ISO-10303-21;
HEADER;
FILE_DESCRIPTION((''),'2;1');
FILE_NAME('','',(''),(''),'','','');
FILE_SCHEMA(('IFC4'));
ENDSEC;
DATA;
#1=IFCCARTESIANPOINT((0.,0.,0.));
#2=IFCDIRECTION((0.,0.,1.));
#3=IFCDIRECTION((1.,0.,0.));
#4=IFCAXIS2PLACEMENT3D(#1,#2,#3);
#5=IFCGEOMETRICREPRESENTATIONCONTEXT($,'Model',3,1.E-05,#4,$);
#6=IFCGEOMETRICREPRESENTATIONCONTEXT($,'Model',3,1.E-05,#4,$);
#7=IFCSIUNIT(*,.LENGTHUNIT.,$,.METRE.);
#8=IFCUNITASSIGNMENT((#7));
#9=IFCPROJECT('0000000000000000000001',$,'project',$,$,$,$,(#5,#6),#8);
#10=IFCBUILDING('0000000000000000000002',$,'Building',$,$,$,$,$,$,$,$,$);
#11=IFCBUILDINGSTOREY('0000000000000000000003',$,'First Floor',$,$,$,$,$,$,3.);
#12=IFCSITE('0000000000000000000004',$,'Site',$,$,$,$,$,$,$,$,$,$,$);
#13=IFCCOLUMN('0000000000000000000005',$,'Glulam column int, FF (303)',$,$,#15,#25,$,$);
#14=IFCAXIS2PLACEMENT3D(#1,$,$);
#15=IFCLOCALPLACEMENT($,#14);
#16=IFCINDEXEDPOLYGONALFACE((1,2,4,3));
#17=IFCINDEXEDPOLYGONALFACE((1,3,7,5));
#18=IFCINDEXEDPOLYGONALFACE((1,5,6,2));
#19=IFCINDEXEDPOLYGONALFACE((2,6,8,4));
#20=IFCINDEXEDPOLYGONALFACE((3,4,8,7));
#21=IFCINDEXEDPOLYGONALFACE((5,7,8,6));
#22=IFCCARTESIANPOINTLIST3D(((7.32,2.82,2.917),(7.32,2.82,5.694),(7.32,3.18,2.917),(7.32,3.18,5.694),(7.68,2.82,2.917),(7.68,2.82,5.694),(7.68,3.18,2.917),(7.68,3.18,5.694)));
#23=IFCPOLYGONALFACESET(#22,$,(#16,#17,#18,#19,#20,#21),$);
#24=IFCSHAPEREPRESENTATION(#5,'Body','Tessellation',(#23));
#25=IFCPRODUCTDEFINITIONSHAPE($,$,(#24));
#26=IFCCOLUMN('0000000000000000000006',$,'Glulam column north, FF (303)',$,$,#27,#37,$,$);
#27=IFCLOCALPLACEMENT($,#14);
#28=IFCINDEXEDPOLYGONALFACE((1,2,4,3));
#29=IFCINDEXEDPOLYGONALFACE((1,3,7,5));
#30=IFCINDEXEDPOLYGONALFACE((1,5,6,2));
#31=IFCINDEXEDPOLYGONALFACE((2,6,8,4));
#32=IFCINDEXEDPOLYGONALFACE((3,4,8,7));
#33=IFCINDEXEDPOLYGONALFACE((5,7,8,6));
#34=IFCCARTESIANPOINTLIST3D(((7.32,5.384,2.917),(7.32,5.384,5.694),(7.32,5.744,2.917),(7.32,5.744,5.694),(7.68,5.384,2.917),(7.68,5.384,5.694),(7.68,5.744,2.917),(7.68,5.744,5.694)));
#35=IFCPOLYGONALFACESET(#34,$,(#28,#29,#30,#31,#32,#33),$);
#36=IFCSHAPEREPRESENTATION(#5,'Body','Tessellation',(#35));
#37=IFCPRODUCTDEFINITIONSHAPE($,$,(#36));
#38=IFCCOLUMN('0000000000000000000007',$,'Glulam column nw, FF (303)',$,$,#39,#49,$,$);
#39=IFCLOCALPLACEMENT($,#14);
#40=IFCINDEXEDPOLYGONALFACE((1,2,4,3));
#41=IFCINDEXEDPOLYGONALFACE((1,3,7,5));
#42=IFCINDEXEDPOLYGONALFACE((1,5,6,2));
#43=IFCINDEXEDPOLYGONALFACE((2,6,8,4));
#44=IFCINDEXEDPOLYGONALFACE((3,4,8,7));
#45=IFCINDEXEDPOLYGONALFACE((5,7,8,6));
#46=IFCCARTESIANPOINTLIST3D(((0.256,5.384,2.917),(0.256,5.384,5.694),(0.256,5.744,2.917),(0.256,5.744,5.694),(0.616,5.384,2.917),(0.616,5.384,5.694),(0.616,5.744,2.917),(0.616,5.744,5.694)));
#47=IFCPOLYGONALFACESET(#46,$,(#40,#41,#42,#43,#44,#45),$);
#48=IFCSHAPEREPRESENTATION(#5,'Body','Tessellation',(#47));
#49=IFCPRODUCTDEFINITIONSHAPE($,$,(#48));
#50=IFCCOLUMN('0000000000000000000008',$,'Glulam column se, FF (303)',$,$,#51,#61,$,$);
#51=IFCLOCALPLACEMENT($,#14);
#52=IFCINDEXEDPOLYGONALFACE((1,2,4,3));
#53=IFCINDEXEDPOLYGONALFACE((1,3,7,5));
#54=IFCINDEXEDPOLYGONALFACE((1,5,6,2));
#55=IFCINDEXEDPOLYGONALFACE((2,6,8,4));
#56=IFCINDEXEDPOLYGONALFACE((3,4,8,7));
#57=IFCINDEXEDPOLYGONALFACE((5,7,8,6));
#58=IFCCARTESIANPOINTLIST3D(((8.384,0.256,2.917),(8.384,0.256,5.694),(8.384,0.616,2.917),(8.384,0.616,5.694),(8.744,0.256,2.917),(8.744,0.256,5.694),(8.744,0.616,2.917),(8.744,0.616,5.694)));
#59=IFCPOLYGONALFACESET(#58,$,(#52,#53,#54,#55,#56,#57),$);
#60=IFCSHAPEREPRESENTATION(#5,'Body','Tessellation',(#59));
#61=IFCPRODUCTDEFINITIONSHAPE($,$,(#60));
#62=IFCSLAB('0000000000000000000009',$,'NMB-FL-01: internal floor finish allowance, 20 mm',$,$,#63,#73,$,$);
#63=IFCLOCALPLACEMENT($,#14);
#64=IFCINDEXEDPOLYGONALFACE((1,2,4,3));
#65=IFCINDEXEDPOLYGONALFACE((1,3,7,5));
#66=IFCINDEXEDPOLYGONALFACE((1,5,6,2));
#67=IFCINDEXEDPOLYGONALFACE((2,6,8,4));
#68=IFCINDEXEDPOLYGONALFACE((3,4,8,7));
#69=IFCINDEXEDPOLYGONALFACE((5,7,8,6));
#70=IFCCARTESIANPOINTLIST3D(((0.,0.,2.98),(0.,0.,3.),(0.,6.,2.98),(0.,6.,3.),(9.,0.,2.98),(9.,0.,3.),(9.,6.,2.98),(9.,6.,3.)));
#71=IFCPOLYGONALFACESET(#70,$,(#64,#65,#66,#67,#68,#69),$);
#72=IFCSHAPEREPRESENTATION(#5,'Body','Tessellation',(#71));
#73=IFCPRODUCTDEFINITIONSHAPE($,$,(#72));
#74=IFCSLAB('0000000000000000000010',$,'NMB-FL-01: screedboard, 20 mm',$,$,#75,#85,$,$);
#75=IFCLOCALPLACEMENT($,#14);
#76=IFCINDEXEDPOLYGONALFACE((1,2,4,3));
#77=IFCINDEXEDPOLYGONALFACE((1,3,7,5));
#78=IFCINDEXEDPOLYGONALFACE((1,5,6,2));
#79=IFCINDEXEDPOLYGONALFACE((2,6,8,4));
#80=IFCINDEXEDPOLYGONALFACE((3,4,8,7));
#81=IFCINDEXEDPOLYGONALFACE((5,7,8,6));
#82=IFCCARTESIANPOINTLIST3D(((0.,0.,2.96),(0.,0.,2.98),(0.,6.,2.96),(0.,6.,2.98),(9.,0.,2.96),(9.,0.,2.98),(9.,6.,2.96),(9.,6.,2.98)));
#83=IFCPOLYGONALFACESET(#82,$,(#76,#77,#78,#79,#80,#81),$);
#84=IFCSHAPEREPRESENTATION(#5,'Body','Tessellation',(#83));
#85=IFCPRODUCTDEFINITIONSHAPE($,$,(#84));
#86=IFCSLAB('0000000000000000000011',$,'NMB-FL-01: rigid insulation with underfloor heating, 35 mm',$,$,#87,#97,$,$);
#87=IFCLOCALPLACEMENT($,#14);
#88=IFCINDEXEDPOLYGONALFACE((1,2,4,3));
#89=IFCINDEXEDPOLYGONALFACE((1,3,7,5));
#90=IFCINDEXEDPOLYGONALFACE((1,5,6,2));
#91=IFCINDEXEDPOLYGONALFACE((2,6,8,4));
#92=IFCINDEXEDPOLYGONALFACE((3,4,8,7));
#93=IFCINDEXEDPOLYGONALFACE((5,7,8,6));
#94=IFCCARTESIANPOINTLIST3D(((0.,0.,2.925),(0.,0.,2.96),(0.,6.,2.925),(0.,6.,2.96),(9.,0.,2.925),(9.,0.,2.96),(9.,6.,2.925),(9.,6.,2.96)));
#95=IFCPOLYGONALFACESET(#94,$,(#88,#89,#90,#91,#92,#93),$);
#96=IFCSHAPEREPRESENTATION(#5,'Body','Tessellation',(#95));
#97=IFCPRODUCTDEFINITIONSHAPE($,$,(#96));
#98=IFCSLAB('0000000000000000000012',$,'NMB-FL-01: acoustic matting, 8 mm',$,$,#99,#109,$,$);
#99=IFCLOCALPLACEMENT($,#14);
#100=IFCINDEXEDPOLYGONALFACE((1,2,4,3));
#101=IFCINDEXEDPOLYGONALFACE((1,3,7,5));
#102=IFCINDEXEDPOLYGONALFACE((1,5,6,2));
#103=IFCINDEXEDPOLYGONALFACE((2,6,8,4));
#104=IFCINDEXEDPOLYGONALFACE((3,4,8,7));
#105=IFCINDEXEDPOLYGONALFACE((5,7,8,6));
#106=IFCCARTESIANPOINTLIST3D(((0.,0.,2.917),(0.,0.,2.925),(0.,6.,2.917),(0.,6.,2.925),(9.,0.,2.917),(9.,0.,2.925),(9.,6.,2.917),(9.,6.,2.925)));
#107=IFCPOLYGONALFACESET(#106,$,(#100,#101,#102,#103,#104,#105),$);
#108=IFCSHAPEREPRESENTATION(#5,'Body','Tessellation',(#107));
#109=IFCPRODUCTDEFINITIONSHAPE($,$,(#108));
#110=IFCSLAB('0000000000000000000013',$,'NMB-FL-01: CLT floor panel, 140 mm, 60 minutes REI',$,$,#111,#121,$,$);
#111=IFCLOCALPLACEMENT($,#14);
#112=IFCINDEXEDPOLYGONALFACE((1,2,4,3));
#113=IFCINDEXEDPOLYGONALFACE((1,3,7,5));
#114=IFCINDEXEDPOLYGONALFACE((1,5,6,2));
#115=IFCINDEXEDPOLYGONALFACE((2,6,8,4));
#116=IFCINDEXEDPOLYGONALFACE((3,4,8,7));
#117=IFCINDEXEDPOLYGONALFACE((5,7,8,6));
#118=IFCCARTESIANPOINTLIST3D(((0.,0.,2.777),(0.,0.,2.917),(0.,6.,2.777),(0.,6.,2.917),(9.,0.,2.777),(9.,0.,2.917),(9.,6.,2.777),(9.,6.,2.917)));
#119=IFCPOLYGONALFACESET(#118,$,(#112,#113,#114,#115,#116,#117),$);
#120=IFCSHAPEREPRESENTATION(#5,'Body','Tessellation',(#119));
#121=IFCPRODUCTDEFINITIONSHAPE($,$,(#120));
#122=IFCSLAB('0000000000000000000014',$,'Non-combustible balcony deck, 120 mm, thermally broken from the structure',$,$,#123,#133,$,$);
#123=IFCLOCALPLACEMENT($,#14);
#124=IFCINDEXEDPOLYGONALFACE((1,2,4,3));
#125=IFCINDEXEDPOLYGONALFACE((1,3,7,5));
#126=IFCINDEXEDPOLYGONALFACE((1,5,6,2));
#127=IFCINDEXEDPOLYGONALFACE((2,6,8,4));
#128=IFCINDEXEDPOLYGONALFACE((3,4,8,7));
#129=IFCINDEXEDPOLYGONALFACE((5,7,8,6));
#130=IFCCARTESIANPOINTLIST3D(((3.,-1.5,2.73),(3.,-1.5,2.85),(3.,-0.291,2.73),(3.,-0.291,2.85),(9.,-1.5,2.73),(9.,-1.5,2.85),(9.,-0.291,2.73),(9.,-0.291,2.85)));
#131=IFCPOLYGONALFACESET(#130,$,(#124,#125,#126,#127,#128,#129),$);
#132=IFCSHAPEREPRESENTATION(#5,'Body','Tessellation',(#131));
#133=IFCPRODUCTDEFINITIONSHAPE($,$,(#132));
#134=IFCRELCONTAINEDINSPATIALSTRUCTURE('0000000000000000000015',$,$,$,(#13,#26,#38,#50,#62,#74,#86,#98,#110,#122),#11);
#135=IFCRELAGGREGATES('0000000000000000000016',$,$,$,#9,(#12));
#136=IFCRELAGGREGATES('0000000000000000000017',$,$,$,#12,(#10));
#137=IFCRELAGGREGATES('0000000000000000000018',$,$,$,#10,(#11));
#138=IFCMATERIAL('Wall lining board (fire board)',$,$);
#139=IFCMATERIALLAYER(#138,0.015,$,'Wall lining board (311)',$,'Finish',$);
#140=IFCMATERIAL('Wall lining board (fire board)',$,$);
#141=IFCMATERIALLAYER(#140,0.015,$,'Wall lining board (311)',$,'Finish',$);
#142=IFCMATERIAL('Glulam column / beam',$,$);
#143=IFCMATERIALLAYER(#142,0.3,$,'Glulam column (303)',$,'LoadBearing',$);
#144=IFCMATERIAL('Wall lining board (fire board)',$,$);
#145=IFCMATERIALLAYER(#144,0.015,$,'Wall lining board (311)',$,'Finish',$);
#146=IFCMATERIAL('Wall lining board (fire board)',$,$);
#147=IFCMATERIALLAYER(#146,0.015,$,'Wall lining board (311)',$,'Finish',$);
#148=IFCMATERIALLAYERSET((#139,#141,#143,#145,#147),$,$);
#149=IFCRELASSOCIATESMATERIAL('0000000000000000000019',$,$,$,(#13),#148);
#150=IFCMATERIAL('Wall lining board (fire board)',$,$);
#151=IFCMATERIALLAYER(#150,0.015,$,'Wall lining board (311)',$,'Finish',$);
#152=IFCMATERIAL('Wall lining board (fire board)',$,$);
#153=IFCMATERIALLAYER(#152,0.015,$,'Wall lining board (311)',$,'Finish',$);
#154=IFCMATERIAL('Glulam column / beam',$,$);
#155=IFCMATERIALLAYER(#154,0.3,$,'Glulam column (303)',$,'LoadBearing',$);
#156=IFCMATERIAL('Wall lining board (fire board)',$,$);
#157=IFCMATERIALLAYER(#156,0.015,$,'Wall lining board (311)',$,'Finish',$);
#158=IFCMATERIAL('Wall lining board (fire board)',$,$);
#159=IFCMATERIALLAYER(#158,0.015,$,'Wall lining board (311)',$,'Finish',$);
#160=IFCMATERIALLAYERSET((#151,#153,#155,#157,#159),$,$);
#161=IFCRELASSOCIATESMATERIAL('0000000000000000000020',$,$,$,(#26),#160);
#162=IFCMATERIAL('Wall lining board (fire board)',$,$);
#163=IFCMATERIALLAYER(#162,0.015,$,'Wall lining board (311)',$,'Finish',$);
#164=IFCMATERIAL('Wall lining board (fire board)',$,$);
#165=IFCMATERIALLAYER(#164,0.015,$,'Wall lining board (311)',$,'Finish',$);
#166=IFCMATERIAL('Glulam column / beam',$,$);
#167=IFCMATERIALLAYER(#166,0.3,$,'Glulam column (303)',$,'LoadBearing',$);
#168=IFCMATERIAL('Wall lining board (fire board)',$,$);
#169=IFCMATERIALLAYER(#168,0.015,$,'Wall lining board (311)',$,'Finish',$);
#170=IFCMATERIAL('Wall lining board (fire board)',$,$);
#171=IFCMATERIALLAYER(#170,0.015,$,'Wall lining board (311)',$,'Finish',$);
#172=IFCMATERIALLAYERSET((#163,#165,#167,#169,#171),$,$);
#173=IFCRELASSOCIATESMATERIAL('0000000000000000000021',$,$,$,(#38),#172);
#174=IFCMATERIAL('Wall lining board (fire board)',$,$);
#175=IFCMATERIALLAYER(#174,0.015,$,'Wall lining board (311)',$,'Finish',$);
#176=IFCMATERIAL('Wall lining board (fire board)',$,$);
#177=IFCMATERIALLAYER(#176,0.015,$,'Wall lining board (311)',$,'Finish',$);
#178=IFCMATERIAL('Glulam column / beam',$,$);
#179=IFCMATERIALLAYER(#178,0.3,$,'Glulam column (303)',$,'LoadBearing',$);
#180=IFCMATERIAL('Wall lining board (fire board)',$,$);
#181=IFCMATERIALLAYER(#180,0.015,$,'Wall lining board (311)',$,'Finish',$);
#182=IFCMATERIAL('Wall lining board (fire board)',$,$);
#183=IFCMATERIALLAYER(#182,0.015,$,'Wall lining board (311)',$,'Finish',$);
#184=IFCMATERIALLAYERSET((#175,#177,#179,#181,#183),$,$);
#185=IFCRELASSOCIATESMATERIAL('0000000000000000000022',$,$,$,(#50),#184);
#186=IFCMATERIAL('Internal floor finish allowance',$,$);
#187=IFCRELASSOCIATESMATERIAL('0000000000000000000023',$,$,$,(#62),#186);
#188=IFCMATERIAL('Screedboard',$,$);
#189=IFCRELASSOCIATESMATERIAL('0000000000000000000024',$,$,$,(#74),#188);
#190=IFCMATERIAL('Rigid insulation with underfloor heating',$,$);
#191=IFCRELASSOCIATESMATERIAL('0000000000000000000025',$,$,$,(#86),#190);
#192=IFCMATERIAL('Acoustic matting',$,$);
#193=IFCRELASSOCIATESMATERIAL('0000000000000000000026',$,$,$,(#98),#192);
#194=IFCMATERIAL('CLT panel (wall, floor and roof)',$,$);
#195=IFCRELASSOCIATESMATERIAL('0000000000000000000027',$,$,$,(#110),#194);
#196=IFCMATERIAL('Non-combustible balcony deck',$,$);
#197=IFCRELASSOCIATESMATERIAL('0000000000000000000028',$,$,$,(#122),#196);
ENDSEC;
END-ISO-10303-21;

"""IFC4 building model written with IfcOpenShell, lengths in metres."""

from ifc_helpers import new_model, si_unit, frame, frame_2d, origin, origin_with_axes, place, context, project, spatial, polyline, rectangle, outline, extrude, material, layer, layer_set, layer_usage, element, save


model = new_model("IFC4")

# Units and contexts
model_context_1 = context("Model", 3, precision=1e-05, world=origin_with_axes())
model_context_2 = context("Model", 3, precision=1e-05, world=origin_with_axes())
ifc_project = project(units=[si_unit("LENGTHUNIT", "METRE")], contexts=[model_context_1, model_context_2])

# Site, building, storey
site = spatial("IfcSite", under=ifc_project, Name="Site")
building = spatial("IfcBuilding", under=site, Name="Building")
storey = spatial("IfcBuildingStorey", under=building, Name="First Floor", Elevation=3.0)

# Columns
ifc_material_1 = material(Name="Wall lining board (fire board)")
ifc_layer_1 = layer(ifc_material_1, 0.015, Name="Wall lining board (311)", Category="Finish")
ifc_material_2 = material(Name="Wall lining board (fire board)")
ifc_layer_2 = layer(ifc_material_2, 0.015, Name="Wall lining board (311)", Category="Finish")
ifc_material_3 = material(Name="Glulam column / beam")
ifc_layer_3 = layer(ifc_material_3, 0.3, Name="Glulam column (303)", Category="LoadBearing")
ifc_material_4 = material(Name="Wall lining board (fire board)")
ifc_layer_4 = layer(ifc_material_4, 0.015, Name="Wall lining board (311)", Category="Finish")
ifc_material_5 = material(Name="Wall lining board (fire board)")
ifc_layer_5 = layer(ifc_material_5, 0.015, Name="Wall lining board (311)", Category="Finish")
ifc_layer_set_1 = layer_set([ifc_layer_1, ifc_layer_2, ifc_layer_3, ifc_layer_4, ifc_layer_5])
ifc_layer_usage_1 = layer_usage(ifc_layer_set_1, "AXIS2", "NEGATIVE", 0.18)
column_1_placement = place(None, frame((7.32, 3.0, 2.917), z_axis=(0.0, 0.0, 1.0), x_axis=(1.0, 0.0, 0.0)))
element("IfcColumn", 1, at=column_1_placement, inside=storey, material=ifc_layer_usage_1, Name="Glulam column int, FF (303)", context=model_context_1, shape_type="SweptSolid", body=[
    extrude(rectangle(XDim=0.36, YDim=2.777, at=frame_2d((0.0, 1.3885))), frame((0.0, 0.0, 0.0), z_axis=(1.0, 0.0, 0.0), x_axis=(0.0, 1.0, 0.0)), (0.0, 0.0, 1.0), 0.36),
])
ifc_material_6 = material(Name="Wall lining board (fire board)")
ifc_layer_6 = layer(ifc_material_6, 0.015, Name="Wall lining board (311)", Category="Finish")
ifc_material_7 = material(Name="Wall lining board (fire board)")
ifc_layer_7 = layer(ifc_material_7, 0.015, Name="Wall lining board (311)", Category="Finish")
ifc_material_8 = material(Name="Glulam column / beam")
ifc_layer_8 = layer(ifc_material_8, 0.3, Name="Glulam column (303)", Category="LoadBearing")
ifc_material_9 = material(Name="Wall lining board (fire board)")
ifc_layer_9 = layer(ifc_material_9, 0.015, Name="Wall lining board (311)", Category="Finish")
ifc_material_10 = material(Name="Wall lining board (fire board)")
ifc_layer_10 = layer(ifc_material_10, 0.015, Name="Wall lining board (311)", Category="Finish")
ifc_layer_set_2 = layer_set([ifc_layer_6, ifc_layer_7, ifc_layer_8, ifc_layer_9, ifc_layer_10])
ifc_layer_usage_2 = layer_usage(ifc_layer_set_2, "AXIS2", "NEGATIVE", 0.18)
column_2_placement = place(None, frame((7.32, 5.564, 2.917), z_axis=(0.0, 0.0, 1.0), x_axis=(1.0, 0.0, 0.0)))
element("IfcColumn", 2, at=column_2_placement, inside=storey, material=ifc_layer_usage_2, Name="Glulam column north, FF (303)", context=model_context_1, shape_type="SweptSolid", body=[
    extrude(rectangle(XDim=0.36, YDim=2.777, at=frame_2d((0.0, 1.3885))), frame((0.0, 0.0, 0.0), z_axis=(1.0, 0.0, 0.0), x_axis=(0.0, 1.0, 0.0)), (0.0, 0.0, 1.0), 0.36),
])
ifc_material_11 = material(Name="Wall lining board (fire board)")
ifc_layer_11 = layer(ifc_material_11, 0.015, Name="Wall lining board (311)", Category="Finish")
ifc_material_12 = material(Name="Wall lining board (fire board)")
ifc_layer_12 = layer(ifc_material_12, 0.015, Name="Wall lining board (311)", Category="Finish")
ifc_material_13 = material(Name="Glulam column / beam")
ifc_layer_13 = layer(ifc_material_13, 0.3, Name="Glulam column (303)", Category="LoadBearing")
ifc_material_14 = material(Name="Wall lining board (fire board)")
ifc_layer_14 = layer(ifc_material_14, 0.015, Name="Wall lining board (311)", Category="Finish")
ifc_material_15 = material(Name="Wall lining board (fire board)")
ifc_layer_15 = layer(ifc_material_15, 0.015, Name="Wall lining board (311)", Category="Finish")
ifc_layer_set_3 = layer_set([ifc_layer_11, ifc_layer_12, ifc_layer_13, ifc_layer_14, ifc_layer_15])
ifc_layer_usage_3 = layer_usage(ifc_layer_set_3, "AXIS2", "NEGATIVE", 0.18)
column_3_placement = place(None, frame((0.256, 5.564, 2.917), z_axis=(0.0, 0.0, 1.0), x_axis=(1.0, 0.0, 0.0)))
element("IfcColumn", 3, at=column_3_placement, inside=storey, material=ifc_layer_usage_3, Name="Glulam column nw, FF (303)", context=model_context_1, shape_type="SweptSolid", body=[
    extrude(rectangle(XDim=0.36, YDim=2.777, at=frame_2d((0.0, 1.3885))), frame((0.0, 0.0, 0.0), z_axis=(1.0, 0.0, 0.0), x_axis=(0.0, 1.0, 0.0)), (0.0, 0.0, 1.0), 0.36),
])
ifc_material_16 = material(Name="Wall lining board (fire board)")
ifc_layer_16 = layer(ifc_material_16, 0.015, Name="Wall lining board (311)", Category="Finish")
ifc_material_17 = material(Name="Wall lining board (fire board)")
ifc_layer_17 = layer(ifc_material_17, 0.015, Name="Wall lining board (311)", Category="Finish")
ifc_material_18 = material(Name="Glulam column / beam")
ifc_layer_18 = layer(ifc_material_18, 0.3, Name="Glulam column (303)", Category="LoadBearing")
ifc_material_19 = material(Name="Wall lining board (fire board)")
ifc_layer_19 = layer(ifc_material_19, 0.015, Name="Wall lining board (311)", Category="Finish")
ifc_material_20 = material(Name="Wall lining board (fire board)")
ifc_layer_20 = layer(ifc_material_20, 0.015, Name="Wall lining board (311)", Category="Finish")
ifc_layer_set_4 = layer_set([ifc_layer_16, ifc_layer_17, ifc_layer_18, ifc_layer_19, ifc_layer_20])
ifc_layer_usage_4 = layer_usage(ifc_layer_set_4, "AXIS2", "NEGATIVE", 0.18)
column_4_placement = place(None, frame((8.384, 0.436, 2.917), z_axis=(0.0, 0.0, 1.0), x_axis=(1.0, 0.0, 0.0)))
element("IfcColumn", 4, at=column_4_placement, inside=storey, material=ifc_layer_usage_4, Name="Glulam column se, FF (303)", context=model_context_1, shape_type="SweptSolid", body=[
    extrude(rectangle(XDim=0.36, YDim=2.777, at=frame_2d((0.0, 1.3885))), frame((0.0, 0.0, 0.0), z_axis=(1.0, 0.0, 0.0), x_axis=(0.0, 1.0, 0.0)), (0.0, 0.0, 1.0), 0.36),
])

# Slabs
ifc_material_21 = material(Name="Internal floor finish allowance")
slab_1_placement = place(None, frame((0.0, 0.0, 3.0), z_axis=(0.0, 0.0, 1.0), x_axis=(1.0, 0.0, 0.0)))
element("IfcSlab", 5, at=slab_1_placement, inside=storey, material=ifc_material_21, Name="NMB-FL-01: internal floor finish allowance, 20 mm", context=model_context_1, shape_type="SweptSolid", body=[
    extrude(outline(polyline([(0.0, 0.0), (0.0, 6.0), (9.0, 6.0), (9.0, 0.0), (0.0, 0.0)])), origin(), (0.0, 0.0, -1.0), 0.02),
])
ifc_material_22 = material(Name="Screedboard")
slab_2_placement = place(None, frame((0.0, 0.0, 2.98), z_axis=(0.0, 0.0, 1.0), x_axis=(1.0, 0.0, 0.0)))
element("IfcSlab", 6, at=slab_2_placement, inside=storey, material=ifc_material_22, Name="NMB-FL-01: screedboard, 20 mm", context=model_context_1, shape_type="SweptSolid", body=[
    extrude(outline(polyline([(0.0, 0.0), (0.0, 6.0), (9.0, 6.0), (9.0, 0.0), (0.0, 0.0)])), origin(), (0.0, 0.0, -1.0), 0.02),
])
ifc_material_23 = material(Name="Rigid insulation with underfloor heating")
slab_3_placement = place(None, frame((0.0, 0.0, 2.96), z_axis=(0.0, 0.0, 1.0), x_axis=(1.0, 0.0, 0.0)))
element("IfcSlab", 7, at=slab_3_placement, inside=storey, material=ifc_material_23, Name="NMB-FL-01: rigid insulation with underfloor heating, 35 mm", context=model_context_1, shape_type="SweptSolid", body=[
    extrude(outline(polyline([(0.0, 0.0), (0.0, 6.0), (9.0, 6.0), (9.0, 0.0), (0.0, 0.0)])), origin(), (0.0, 0.0, -1.0), 0.035),
])
ifc_material_24 = material(Name="Acoustic matting")
slab_4_placement = place(None, frame((0.0, 0.0, 2.925), z_axis=(0.0, 0.0, 1.0), x_axis=(1.0, 0.0, 0.0)))
element("IfcSlab", 8, at=slab_4_placement, inside=storey, material=ifc_material_24, Name="NMB-FL-01: acoustic matting, 8 mm", context=model_context_1, shape_type="SweptSolid", body=[
    extrude(outline(polyline([(0.0, 0.0), (0.0, 6.0), (9.0, 6.0), (9.0, 0.0), (0.0, 0.0)])), origin(), (0.0, 0.0, -1.0), 0.008),
])
ifc_material_25 = material(Name="CLT panel (wall, floor and roof)")
slab_5_placement = place(None, frame((0.0, 0.0, 2.917), z_axis=(0.0, 0.0, 1.0), x_axis=(1.0, 0.0, 0.0)))
element("IfcSlab", 9, at=slab_5_placement, inside=storey, material=ifc_material_25, Name="NMB-FL-01: CLT floor panel, 140 mm, 60 minutes REI", context=model_context_1, shape_type="SweptSolid", body=[
    extrude(outline(polyline([(0.0, 0.0), (0.0, 6.0), (9.0, 6.0), (9.0, 0.0), (0.0, 0.0)])), origin(), (0.0, 0.0, -1.0), 0.14),
])
ifc_material_26 = material(Name="Non-combustible balcony deck")
slab_6_placement = place(None, frame((0.0, 0.0, 2.85), z_axis=(0.0, 0.0, 1.0), x_axis=(1.0, 0.0, 0.0)))
element("IfcSlab", 10, at=slab_6_placement, inside=storey, material=ifc_material_26, Name="Non-combustible balcony deck, 120 mm, thermally broken from the structure", context=model_context_1, shape_type="SweptSolid", body=[
    extrude(outline(polyline([(3.0, -1.5), (3.0, -0.291), (9.0, -0.291), (9.0, -1.5), (3.0, -1.5)])), origin(), (0.0, 0.0, -1.0), 0.12),
])

save(model, "model.ifc")
